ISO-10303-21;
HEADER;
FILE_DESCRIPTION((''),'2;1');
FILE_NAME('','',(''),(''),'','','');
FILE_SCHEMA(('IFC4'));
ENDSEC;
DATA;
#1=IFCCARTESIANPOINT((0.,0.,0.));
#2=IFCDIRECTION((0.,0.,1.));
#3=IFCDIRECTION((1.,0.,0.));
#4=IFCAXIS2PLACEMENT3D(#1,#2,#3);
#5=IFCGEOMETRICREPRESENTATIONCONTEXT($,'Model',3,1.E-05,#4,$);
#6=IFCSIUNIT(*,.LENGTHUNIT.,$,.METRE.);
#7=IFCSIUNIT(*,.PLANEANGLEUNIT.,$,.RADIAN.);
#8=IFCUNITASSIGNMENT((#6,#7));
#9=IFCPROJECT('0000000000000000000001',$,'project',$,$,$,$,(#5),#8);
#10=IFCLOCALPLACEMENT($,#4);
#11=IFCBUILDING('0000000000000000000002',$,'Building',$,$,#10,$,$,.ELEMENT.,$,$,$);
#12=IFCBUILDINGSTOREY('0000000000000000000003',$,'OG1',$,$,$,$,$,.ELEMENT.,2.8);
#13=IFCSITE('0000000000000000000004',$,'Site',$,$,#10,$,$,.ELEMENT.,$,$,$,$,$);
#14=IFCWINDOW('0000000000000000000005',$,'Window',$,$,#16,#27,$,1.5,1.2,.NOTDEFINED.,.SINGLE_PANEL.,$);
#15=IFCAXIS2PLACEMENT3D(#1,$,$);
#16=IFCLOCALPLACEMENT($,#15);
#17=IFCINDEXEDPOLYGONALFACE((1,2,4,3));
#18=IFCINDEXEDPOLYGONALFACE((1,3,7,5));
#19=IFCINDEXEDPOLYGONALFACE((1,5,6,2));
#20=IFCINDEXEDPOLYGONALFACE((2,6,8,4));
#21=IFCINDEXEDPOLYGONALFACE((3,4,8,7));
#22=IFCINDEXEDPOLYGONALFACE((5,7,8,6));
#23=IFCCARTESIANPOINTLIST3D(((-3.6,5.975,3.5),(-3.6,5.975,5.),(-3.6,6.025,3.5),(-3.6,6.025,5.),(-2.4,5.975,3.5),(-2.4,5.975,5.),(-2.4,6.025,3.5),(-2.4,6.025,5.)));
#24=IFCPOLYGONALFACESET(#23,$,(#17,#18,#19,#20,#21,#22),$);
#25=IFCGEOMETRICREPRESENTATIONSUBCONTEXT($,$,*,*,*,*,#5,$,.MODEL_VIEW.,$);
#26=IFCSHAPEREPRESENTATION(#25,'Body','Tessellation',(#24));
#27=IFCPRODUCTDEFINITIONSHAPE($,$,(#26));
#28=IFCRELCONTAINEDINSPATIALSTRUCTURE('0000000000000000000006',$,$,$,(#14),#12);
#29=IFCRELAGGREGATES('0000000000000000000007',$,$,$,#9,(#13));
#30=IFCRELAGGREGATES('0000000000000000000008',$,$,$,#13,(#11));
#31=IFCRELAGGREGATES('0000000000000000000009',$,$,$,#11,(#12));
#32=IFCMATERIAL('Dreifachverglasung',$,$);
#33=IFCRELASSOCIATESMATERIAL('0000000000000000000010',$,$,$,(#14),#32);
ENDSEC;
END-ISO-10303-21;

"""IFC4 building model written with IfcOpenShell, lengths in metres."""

from ifc_helpers import new_model, si_unit, frame, origin, origin_with_axes, origin_2d, place, context, subcontext, project, spatial, rectangle, extrude, material, element, save


model = new_model("IFC4")

# Units and contexts
model_context = context("Model", 3, precision=1e-05, world=origin_with_axes())
sub_context = subcontext(model_context, None, None, "MODEL_VIEW")
ifc_project = project(units=[si_unit("LENGTHUNIT", "METRE"), si_unit("PLANEANGLEUNIT", "RADIAN")], contexts=[model_context])

# Site, building, storey
placement_1 = place(None, origin_with_axes())
site = spatial("IfcSite", under=ifc_project, at=placement_1, Name="Site", CompositionType="ELEMENT")
building = spatial("IfcBuilding", under=site, at=placement_1, Name="Building", CompositionType="ELEMENT")
storey = spatial("IfcBuildingStorey", under=building, Name="OG1", CompositionType="ELEMENT", Elevation=2.8)

# Window
ifc_material = material(Name="Dreifachverglasung")
placement_2 = place(None, origin_with_axes())
window_placement = place(placement_2, frame((-3.0, 6.0, 3.5)))
element("IfcWindow", 1, at=window_placement, inside=storey, material=ifc_material, Name="Window", OverallHeight=1.5, OverallWidth=1.2, PartitioningType="SINGLE_PANEL", PredefinedType="NOTDEFINED", context=sub_context, shape_type="SweptSolid", body=[
    extrude(rectangle(XDim=1.2, YDim=0.05, at=origin_2d()), origin(), (0.0, 0.0, 1.0), 1.5),
])

save(model, "model.ifc")
